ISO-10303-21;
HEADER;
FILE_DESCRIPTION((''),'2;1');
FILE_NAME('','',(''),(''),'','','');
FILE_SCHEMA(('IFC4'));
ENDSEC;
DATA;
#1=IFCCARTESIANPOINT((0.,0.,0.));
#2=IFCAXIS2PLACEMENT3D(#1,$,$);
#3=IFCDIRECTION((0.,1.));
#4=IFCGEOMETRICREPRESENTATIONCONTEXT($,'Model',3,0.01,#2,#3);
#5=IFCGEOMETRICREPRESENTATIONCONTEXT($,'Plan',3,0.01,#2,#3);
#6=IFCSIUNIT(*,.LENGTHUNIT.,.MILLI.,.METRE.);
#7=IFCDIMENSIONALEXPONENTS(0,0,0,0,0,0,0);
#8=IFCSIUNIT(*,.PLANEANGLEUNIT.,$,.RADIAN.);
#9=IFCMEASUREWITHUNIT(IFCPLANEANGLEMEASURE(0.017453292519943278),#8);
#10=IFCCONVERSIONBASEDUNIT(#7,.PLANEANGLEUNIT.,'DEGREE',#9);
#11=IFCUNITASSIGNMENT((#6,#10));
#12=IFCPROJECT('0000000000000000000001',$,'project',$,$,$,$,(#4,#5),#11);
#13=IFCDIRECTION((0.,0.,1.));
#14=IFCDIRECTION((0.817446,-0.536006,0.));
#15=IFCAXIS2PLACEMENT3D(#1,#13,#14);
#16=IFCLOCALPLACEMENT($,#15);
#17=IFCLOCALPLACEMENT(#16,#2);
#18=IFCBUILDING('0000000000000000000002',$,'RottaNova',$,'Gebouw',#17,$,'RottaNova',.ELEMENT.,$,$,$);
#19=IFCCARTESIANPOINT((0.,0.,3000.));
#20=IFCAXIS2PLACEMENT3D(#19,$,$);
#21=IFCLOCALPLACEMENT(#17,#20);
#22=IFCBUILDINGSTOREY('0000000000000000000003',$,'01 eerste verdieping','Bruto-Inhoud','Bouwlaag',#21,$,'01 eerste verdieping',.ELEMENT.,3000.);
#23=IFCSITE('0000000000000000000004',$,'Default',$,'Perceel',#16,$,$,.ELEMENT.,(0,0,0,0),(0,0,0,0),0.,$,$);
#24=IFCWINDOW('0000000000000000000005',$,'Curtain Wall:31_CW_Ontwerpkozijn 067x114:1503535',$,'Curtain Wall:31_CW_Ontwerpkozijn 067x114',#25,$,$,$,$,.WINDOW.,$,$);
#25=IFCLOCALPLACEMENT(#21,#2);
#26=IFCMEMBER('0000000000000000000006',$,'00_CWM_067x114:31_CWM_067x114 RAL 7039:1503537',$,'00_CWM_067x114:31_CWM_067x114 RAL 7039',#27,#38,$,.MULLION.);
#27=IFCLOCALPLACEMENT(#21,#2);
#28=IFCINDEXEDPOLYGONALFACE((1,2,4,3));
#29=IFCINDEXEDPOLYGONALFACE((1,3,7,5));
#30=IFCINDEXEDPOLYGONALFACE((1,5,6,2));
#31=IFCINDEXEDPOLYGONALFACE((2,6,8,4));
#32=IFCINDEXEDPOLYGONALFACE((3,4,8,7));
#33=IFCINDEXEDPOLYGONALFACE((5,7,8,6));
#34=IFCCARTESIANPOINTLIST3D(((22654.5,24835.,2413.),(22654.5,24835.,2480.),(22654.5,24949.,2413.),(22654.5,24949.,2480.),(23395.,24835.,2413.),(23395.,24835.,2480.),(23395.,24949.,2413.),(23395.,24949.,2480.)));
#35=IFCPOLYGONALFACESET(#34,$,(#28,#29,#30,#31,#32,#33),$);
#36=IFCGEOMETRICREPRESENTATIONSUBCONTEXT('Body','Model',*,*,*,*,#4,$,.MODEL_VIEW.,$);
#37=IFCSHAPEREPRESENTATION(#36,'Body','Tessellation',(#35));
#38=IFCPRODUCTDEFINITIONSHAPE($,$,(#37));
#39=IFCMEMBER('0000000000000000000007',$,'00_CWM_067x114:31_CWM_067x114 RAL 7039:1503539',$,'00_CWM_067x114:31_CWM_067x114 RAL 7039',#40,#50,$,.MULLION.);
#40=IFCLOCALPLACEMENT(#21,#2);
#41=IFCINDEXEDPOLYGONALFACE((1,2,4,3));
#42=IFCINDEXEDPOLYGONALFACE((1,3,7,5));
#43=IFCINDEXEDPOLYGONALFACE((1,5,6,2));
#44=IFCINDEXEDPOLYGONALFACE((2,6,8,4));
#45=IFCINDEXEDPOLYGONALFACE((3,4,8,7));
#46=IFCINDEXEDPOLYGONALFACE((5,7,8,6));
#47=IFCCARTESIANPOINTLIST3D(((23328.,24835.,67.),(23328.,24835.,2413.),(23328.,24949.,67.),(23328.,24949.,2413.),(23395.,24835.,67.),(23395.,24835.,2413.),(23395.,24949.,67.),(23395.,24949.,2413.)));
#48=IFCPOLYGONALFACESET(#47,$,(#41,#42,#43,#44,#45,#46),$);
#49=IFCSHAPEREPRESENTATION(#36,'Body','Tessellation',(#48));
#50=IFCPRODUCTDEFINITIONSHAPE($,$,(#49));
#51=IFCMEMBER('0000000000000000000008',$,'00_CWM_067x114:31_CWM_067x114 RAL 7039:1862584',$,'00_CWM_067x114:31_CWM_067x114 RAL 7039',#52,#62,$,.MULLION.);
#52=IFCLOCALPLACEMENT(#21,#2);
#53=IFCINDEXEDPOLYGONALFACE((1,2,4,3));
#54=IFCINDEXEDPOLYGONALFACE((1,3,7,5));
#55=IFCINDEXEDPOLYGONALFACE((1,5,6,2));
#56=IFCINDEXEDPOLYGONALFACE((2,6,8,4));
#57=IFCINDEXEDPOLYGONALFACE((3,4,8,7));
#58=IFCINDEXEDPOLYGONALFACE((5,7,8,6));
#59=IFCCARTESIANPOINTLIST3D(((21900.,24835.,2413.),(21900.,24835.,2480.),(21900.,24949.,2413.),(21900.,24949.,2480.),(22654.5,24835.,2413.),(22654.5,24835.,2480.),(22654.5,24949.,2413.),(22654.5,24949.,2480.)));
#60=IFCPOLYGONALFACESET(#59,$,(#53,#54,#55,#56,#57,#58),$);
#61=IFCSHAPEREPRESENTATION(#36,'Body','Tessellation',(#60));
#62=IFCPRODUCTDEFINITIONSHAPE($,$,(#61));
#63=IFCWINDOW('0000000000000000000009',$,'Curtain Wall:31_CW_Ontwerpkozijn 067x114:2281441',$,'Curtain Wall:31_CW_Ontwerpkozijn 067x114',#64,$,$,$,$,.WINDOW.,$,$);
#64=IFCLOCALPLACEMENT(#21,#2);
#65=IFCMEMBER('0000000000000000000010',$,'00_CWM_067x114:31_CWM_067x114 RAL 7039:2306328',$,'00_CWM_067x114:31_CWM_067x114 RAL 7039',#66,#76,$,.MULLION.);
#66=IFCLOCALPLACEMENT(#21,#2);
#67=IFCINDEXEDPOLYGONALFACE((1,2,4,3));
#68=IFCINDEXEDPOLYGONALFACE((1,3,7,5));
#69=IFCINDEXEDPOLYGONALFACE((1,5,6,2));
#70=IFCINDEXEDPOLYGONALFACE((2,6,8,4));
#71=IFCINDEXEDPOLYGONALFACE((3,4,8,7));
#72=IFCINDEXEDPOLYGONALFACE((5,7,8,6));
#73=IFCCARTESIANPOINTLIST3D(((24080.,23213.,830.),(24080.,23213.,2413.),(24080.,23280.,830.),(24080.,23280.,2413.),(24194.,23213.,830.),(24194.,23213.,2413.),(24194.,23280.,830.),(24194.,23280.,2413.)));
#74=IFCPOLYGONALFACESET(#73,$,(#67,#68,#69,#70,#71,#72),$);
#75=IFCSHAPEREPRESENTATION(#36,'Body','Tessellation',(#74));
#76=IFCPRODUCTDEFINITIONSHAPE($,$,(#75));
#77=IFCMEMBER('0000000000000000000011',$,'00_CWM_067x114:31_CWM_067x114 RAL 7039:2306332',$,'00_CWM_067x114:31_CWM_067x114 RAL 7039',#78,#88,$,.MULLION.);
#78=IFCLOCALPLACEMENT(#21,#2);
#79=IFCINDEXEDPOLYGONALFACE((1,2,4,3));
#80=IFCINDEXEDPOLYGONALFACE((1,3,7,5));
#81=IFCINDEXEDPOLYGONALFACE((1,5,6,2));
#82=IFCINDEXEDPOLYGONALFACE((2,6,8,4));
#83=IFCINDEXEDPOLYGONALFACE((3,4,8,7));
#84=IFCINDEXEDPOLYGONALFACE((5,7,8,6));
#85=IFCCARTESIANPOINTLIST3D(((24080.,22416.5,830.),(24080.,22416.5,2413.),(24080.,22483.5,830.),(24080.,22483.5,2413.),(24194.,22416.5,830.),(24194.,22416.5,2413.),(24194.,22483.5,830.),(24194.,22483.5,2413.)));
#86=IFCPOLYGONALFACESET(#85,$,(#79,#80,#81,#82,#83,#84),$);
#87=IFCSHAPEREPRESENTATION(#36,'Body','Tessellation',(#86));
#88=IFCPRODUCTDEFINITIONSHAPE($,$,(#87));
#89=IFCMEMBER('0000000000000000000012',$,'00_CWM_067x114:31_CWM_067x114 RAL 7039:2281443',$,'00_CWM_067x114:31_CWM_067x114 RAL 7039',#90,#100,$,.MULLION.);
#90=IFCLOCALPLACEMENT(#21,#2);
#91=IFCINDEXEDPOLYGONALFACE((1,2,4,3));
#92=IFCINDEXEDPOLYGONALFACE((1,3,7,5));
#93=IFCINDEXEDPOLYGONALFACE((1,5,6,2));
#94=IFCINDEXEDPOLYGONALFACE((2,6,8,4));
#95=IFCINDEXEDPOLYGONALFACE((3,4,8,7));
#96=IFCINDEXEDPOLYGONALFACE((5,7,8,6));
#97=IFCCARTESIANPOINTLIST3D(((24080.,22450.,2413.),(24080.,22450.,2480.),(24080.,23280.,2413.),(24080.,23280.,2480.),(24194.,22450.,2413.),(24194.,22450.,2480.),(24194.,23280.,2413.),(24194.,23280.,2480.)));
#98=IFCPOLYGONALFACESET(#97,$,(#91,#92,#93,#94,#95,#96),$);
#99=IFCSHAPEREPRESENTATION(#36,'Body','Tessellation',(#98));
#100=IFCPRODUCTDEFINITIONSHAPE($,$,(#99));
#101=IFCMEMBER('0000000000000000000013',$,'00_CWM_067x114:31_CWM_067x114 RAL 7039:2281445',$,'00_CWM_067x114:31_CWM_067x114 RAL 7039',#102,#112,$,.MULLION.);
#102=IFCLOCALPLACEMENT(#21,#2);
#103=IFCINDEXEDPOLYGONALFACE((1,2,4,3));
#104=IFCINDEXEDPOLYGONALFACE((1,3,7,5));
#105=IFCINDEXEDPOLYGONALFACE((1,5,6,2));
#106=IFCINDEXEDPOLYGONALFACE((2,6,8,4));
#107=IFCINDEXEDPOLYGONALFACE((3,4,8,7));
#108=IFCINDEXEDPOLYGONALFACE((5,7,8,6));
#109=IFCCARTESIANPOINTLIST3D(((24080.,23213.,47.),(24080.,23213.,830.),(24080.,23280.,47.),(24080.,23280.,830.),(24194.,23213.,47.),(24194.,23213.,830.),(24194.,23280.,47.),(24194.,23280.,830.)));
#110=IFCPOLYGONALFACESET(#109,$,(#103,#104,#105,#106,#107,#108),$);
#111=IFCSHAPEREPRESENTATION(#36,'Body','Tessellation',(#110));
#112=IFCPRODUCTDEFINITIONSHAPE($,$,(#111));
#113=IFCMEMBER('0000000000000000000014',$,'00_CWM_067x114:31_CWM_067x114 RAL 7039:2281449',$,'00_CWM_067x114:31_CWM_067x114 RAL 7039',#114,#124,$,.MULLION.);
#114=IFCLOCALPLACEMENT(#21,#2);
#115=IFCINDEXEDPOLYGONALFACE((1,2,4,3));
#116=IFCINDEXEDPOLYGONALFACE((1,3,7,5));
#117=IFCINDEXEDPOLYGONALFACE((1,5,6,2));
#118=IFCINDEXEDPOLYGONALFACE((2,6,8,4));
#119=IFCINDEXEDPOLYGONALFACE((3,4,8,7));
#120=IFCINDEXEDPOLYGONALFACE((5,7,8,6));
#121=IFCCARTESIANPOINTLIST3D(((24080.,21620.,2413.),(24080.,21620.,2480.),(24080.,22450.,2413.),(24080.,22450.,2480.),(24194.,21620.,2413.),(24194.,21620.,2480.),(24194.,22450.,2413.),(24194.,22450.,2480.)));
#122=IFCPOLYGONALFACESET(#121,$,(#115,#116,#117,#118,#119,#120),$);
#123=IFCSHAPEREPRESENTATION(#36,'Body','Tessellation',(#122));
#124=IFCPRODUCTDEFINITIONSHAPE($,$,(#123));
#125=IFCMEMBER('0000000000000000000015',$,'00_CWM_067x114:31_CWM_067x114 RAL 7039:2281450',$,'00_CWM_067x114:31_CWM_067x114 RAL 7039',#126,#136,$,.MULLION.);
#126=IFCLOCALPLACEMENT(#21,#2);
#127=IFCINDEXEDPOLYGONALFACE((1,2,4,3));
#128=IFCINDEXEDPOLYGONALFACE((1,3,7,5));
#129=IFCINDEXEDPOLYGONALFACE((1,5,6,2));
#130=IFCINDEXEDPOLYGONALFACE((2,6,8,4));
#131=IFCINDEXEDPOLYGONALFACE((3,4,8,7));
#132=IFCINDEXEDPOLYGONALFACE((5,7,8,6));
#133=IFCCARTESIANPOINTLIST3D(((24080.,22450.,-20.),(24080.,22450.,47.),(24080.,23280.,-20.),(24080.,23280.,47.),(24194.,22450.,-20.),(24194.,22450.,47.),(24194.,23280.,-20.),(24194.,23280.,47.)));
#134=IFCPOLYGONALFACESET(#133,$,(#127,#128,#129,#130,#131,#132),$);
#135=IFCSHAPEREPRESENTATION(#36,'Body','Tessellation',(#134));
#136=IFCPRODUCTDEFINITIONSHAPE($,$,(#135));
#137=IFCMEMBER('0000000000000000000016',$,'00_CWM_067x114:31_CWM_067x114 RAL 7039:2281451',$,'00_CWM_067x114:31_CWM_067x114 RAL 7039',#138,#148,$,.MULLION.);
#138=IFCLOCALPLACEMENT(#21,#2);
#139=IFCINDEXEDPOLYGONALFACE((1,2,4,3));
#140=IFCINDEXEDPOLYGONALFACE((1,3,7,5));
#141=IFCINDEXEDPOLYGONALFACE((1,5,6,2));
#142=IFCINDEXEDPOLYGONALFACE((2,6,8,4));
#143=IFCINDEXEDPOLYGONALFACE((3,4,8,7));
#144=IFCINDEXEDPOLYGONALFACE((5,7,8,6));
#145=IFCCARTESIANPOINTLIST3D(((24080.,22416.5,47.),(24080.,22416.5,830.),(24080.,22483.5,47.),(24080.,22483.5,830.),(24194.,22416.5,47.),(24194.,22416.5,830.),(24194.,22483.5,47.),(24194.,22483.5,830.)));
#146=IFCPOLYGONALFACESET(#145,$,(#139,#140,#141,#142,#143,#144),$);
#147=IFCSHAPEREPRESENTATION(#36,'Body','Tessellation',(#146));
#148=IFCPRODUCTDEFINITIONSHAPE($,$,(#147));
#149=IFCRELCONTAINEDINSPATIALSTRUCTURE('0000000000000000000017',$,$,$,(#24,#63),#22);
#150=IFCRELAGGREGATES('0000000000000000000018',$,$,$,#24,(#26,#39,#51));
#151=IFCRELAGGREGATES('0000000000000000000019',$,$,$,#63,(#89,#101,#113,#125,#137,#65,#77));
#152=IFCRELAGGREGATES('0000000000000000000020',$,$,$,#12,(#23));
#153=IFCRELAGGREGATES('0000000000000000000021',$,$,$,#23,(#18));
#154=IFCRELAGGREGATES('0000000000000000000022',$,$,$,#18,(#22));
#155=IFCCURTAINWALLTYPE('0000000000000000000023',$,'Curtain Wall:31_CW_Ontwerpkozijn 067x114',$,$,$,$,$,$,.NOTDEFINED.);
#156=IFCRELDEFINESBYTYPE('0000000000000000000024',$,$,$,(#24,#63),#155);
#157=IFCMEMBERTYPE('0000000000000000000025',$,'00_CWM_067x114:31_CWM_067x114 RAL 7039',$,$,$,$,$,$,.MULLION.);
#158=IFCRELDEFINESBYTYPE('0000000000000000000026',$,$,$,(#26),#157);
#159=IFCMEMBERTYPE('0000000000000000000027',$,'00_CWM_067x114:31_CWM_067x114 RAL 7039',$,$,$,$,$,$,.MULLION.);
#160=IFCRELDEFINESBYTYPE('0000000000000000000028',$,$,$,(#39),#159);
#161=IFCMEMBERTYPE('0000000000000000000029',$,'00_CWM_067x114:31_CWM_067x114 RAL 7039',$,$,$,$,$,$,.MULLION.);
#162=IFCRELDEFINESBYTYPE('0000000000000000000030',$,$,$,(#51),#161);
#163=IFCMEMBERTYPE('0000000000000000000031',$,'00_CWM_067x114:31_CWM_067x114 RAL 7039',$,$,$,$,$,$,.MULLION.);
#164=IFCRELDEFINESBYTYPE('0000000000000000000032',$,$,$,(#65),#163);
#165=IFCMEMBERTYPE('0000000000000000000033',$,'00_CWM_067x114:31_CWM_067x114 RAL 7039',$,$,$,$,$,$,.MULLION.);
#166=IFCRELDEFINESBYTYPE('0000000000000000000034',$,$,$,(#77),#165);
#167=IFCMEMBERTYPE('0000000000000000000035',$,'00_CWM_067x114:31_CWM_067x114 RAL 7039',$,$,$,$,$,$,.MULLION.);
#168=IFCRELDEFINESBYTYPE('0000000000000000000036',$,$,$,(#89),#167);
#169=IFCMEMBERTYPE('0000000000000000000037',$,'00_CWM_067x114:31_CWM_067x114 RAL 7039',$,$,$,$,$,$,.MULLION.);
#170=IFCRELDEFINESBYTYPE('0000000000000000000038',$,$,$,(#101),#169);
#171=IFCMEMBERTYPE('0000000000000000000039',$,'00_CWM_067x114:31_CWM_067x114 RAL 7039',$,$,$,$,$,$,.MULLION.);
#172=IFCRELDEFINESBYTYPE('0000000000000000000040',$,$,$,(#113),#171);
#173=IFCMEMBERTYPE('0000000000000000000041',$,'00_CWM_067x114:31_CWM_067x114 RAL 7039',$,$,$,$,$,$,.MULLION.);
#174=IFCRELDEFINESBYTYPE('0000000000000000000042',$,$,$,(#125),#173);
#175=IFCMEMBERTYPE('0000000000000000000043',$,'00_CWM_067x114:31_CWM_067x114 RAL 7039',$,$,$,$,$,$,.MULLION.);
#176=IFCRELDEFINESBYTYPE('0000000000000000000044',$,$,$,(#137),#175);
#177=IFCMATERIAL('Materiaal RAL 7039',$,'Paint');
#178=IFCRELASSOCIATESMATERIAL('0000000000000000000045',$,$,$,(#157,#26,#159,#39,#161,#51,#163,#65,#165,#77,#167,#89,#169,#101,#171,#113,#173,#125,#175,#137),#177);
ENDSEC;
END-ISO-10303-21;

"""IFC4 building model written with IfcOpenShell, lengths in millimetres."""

from ifc_helpers import new_model, entity, si_unit, converted_unit, direction, frame, origin, place, context, subcontext, project, spatial, indexed_curve, outline, extrude, source, transform, mapped, material, type_object, type_shapes, element, aggregate, save


model = new_model("IFC4")

# Units and contexts
model_context = context("Model", 3, precision=0.01, world=origin(), true_north=direction((0.0, 1.0)))
plan_context = context("Plan", 3, precision=0.01, world=origin(), true_north=direction((0.0, 1.0)))
body_context = subcontext(model_context, "Body", "Model", "MODEL_VIEW")
ifc_project = project(units=[si_unit("LENGTHUNIT", "METRE", prefix="MILLI"), converted_unit("PLANEANGLEUNIT", "DEGREE", entity("IfcPlaneAngleMeasure", 0.017453292519943278), si_unit("PLANEANGLEUNIT", "RADIAN"), dimensions=[0, 0, 0, 0, 0, 0, 0])], contexts=[model_context, plan_context])

# Site, building, storey
site_placement = place(None, frame((0.0, 0.0, 0.0), z_axis=(0.0, 0.0, 1.0), x_axis=(0.817446, -0.536006, 0.0)))
site = spatial("IfcSite", under=ifc_project, at=site_placement, Name="Default", ObjectType="Perceel", CompositionType="ELEMENT", RefLatitude=(0, 0, 0, 0), RefLongitude=(0, 0, 0, 0), RefElevation=0.0)
building_placement = place(site_placement, origin())
building = spatial("IfcBuilding", under=site, at=building_placement, Name="RottaNova", ObjectType="Gebouw", LongName="RottaNova", CompositionType="ELEMENT")
storey_placement = place(building_placement, frame((0.0, 0.0, 3000.0)))
storey = spatial("IfcBuildingStorey", under=building, at=storey_placement, Name="01 eerste verdieping", Description="Bruto-Inhoud", ObjectType="Bouwlaag", LongName="01 eerste verdieping", CompositionType="ELEMENT", Elevation=3000.0)

# Windows, members
curtain_wall_type = type_object("IfcCurtainWallType", Name="Curtain Wall:31_CW_Ontwerpkozijn 067x114", PredefinedType="NOTDEFINED")
window_1_placement = place(storey_placement, frame((0.0, 0.0, -3000.0)))
window_1 = element("IfcWindow", 1, at=window_1_placement, inside=storey, type_object=curtain_wall_type, Name="Curtain Wall:31_CW_Ontwerpkozijn 067x114:1503535", ObjectType="Curtain Wall:31_CW_Ontwerpkozijn 067x114", PredefinedType="WINDOW")
ifc_material_1 = material(Name="Materiaal RAL 7039", Category="Paint")
member_type_1 = type_object("IfcMemberType", Name="00_CWM_067x114:31_CWM_067x114 RAL 7039", PredefinedType="MULLION", material=ifc_material_1)
shared_shape_1 = source(origin(), body_context, "Body", "SweptSolid", [
    extrude(outline(indexed_curve([(-33.5, -57.0), (33.5, -57.0), (33.5, 57.0), (-33.5, 57.0), (-33.5, -57.0)], self_intersect=False)), frame((-33.5, -57.0, -740.5), z_axis=(0.0, 0.0, 1.0), x_axis=(-1.0, 0.0, 0.0)), (0.0, 0.0, 1.0), 740.5),
])
type_shapes(member_type_1, [shared_shape_1])
member_1_placement = place(window_1_placement, frame((23395.0, 24835.0, 5480.0), z_axis=(1.0, 0.0, 0.0), x_axis=(0.0, 0.0, 1.0)))
member_1 = element("IfcMember", 2, at=member_1_placement, type_object=member_type_1, material=ifc_material_1, Name="00_CWM_067x114:31_CWM_067x114 RAL 7039:1503537", ObjectType="00_CWM_067x114:31_CWM_067x114 RAL 7039", PredefinedType="MULLION", context=body_context, shape_type="MappedRepresentation", body=[
    mapped(shared_shape_1, transform((0.0, 0.0, 0.0), scale=1.0)),
])
member_type_2 = type_object("IfcMemberType", Name="00_CWM_067x114:31_CWM_067x114 RAL 7039", PredefinedType="MULLION", material=ifc_material_1)
shared_shape_2 = source(origin(), body_context, "Body", "SweptSolid", [
    extrude(outline(indexed_curve([(-33.5, -57.0), (33.5, -57.0), (33.5, 57.0), (-33.5, 57.0), (-33.5, -57.0)], self_intersect=False)), frame((-33.5, -57.0, -2346.0), z_axis=(0.0, 0.0, 1.0), x_axis=(-1.0, 0.0, 0.0)), (0.0, 0.0, 1.0), 2346.0),
])
type_shapes(member_type_2, [shared_shape_2])
member_2_placement = place(window_1_placement, frame((23395.0, 24835.0, 3067.0), z_axis=(0.0, 0.0, -1.0), x_axis=(1.0, 0.0, 0.0)))
member_2 = element("IfcMember", 3, at=member_2_placement, type_object=member_type_2, material=ifc_material_1, Name="00_CWM_067x114:31_CWM_067x114 RAL 7039:1503539", ObjectType="00_CWM_067x114:31_CWM_067x114 RAL 7039", PredefinedType="MULLION", context=body_context, shape_type="MappedRepresentation", body=[
    mapped(shared_shape_2, transform((0.0, 0.0, 0.0), scale=1.0)),
])
member_type_3 = type_object("IfcMemberType", Name="00_CWM_067x114:31_CWM_067x114 RAL 7039", PredefinedType="MULLION", material=ifc_material_1)
shared_shape_3 = source(origin(), body_context, "Body", "SweptSolid", [
    extrude(outline(indexed_curve([(-33.5, -57.0), (33.5, -57.0), (33.5, 57.0), (-33.5, 57.0), (-33.5, -57.0)], self_intersect=False)), frame((-33.5, -57.0, -754.5), z_axis=(0.0, 0.0, 1.0), x_axis=(-1.0, 0.0, 0.0)), (0.0, 0.0, 1.0), 754.5),
])
type_shapes(member_type_3, [shared_shape_3])
member_3_placement = place(window_1_placement, frame((22654.5, 24835.0, 5480.0), z_axis=(1.0, 0.0, 0.0), x_axis=(0.0, 0.0, 1.0)))
member_3 = element("IfcMember", 4, at=member_3_placement, type_object=member_type_3, material=ifc_material_1, Name="00_CWM_067x114:31_CWM_067x114 RAL 7039:1862584", ObjectType="00_CWM_067x114:31_CWM_067x114 RAL 7039", PredefinedType="MULLION", context=body_context, shape_type="MappedRepresentation", body=[
    mapped(shared_shape_3, transform((0.0, 0.0, 0.0), scale=1.0)),
])
window_2_placement = place(storey_placement, frame((0.0, 0.0, -3000.0)))
window_2 = element("IfcWindow", 5, at=window_2_placement, inside=storey, type_object=curtain_wall_type, Name="Curtain Wall:31_CW_Ontwerpkozijn 067x114:2281441", ObjectType="Curtain Wall:31_CW_Ontwerpkozijn 067x114", PredefinedType="WINDOW")
member_type_4 = type_object("IfcMemberType", Name="00_CWM_067x114:31_CWM_067x114 RAL 7039", PredefinedType="MULLION", material=ifc_material_1)
shared_shape_4 = source(origin(), body_context, "Body", "SweptSolid", [
    extrude(outline(indexed_curve([(-33.5, -57.0), (33.5, -57.0), (33.5, 57.0), (-33.5, 57.0), (-33.5, -57.0)], self_intersect=False)), frame((-33.5, 57.0, -1583.0), z_axis=(0.0, 0.0, 1.0), x_axis=(-1.0, 0.0, 0.0)), (0.0, 0.0, 1.0), 1583.0),
])
type_shapes(member_type_4, [shared_shape_4])
member_4_placement = place(window_2_placement, frame((24080.0, 23280.0, 3830.0), z_axis=(0.0, 0.0, -1.0), x_axis=(0.0, 1.0, 0.0)))
member_4 = element("IfcMember", 6, at=member_4_placement, type_object=member_type_4, material=ifc_material_1, Name="00_CWM_067x114:31_CWM_067x114 RAL 7039:2306328", ObjectType="00_CWM_067x114:31_CWM_067x114 RAL 7039", PredefinedType="MULLION", context=body_context, shape_type="MappedRepresentation", body=[
    mapped(shared_shape_4, transform((0.0, 0.0, 0.0), scale=1.0)),
])
member_type_5 = type_object("IfcMemberType", Name="00_CWM_067x114:31_CWM_067x114 RAL 7039", PredefinedType="MULLION", material=ifc_material_1)
shared_shape_5 = source(origin(), body_context, "Body", "SweptSolid", [
    extrude(outline(indexed_curve([(-33.5, -57.0), (33.5, -57.0), (33.5, 57.0), (-33.5, 57.0), (-33.5, -57.0)], self_intersect=False)), frame((0.0, 57.0, -1583.0), z_axis=(0.0, 0.0, 1.0), x_axis=(-1.0, 0.0, 0.0)), (0.0, 0.0, 1.0), 1583.0),
])
type_shapes(member_type_5, [shared_shape_5])
member_5_placement = place(window_2_placement, frame((24080.0, 22450.0, 3830.0), z_axis=(0.0, 0.0, -1.0), x_axis=(0.0, 1.0, 0.0)))
member_5 = element("IfcMember", 7, at=member_5_placement, type_object=member_type_5, material=ifc_material_1, Name="00_CWM_067x114:31_CWM_067x114 RAL 7039:2306332", ObjectType="00_CWM_067x114:31_CWM_067x114 RAL 7039", PredefinedType="MULLION", context=body_context, shape_type="MappedRepresentation", body=[
    mapped(shared_shape_5, transform((0.0, 0.0, 0.0), scale=1.0)),
])
member_type_6 = type_object("IfcMemberType", Name="00_CWM_067x114:31_CWM_067x114 RAL 7039", PredefinedType="MULLION", material=ifc_material_1)
shared_shape_6 = source(origin(), body_context, "Body", "SweptSolid", [
    extrude(outline(indexed_curve([(-33.5, -57.0), (33.5, -57.0), (33.5, 57.0), (-33.5, 57.0), (-33.5, -57.0)], self_intersect=False)), frame((-33.5, 57.0, -830.0), z_axis=(0.0, 0.0, 1.0), x_axis=(-1.0, 0.0, 0.0)), (0.0, 0.0, 1.0), 830.0),
])
type_shapes(member_type_6, [shared_shape_6])
member_6_placement = place(window_2_placement, frame((24080.0, 23280.0, 5480.0), z_axis=(0.0, 1.0, 0.0), x_axis=(0.0, 0.0, 1.0)))
member_6 = element("IfcMember", 8, at=member_6_placement, type_object=member_type_6, material=ifc_material_1, Name="00_CWM_067x114:31_CWM_067x114 RAL 7039:2281443", ObjectType="00_CWM_067x114:31_CWM_067x114 RAL 7039", PredefinedType="MULLION", context=body_context, shape_type="MappedRepresentation", body=[
    mapped(shared_shape_6, transform((0.0, 0.0, 0.0), scale=1.0)),
])
member_type_7 = type_object("IfcMemberType", Name="00_CWM_067x114:31_CWM_067x114 RAL 7039", PredefinedType="MULLION", material=ifc_material_1)
shared_shape_7 = source(origin(), body_context, "Body", "SweptSolid", [
    extrude(outline(indexed_curve([(-33.5, -57.0), (33.5, -57.0), (33.5, 57.0), (-33.5, 57.0), (-33.5, -57.0)], self_intersect=False)), frame((-33.5, 57.0, -783.0), z_axis=(0.0, 0.0, 1.0), x_axis=(-1.0, 0.0, 0.0)), (0.0, 0.0, 1.0), 783.0),
])
type_shapes(member_type_7, [shared_shape_7])
member_7_placement = place(window_2_placement, frame((24080.0, 23280.0, 3047.0), z_axis=(0.0, 0.0, -1.0), x_axis=(0.0, 1.0, 0.0)))
member_7 = element("IfcMember", 9, at=member_7_placement, type_object=member_type_7, material=ifc_material_1, Name="00_CWM_067x114:31_CWM_067x114 RAL 7039:2281445", ObjectType="00_CWM_067x114:31_CWM_067x114 RAL 7039", PredefinedType="MULLION", context=body_context, shape_type="MappedRepresentation", body=[
    mapped(shared_shape_7, transform((0.0, 0.0, 0.0), scale=1.0)),
])
member_type_8 = type_object("IfcMemberType", Name="00_CWM_067x114:31_CWM_067x114 RAL 7039", PredefinedType="MULLION", material=ifc_material_1)
shared_shape_8 = source(origin(), body_context, "Body", "SweptSolid", [
    extrude(outline(indexed_curve([(-33.5, -57.0), (33.5, -57.0), (33.5, 57.0), (-33.5, 57.0), (-33.5, -57.0)], self_intersect=False)), frame((-33.5, 57.0, -830.0), z_axis=(0.0, 0.0, 1.0), x_axis=(-1.0, 0.0, 0.0)), (0.0, 0.0, 1.0), 830.0),
])
type_shapes(member_type_8, [shared_shape_8])
member_8_placement = place(window_2_placement, frame((24080.0, 22450.0, 5480.0), z_axis=(0.0, 1.0, 0.0), x_axis=(0.0, 0.0, 1.0)))
member_8 = element("IfcMember", 10, at=member_8_placement, type_object=member_type_8, material=ifc_material_1, Name="00_CWM_067x114:31_CWM_067x114 RAL 7039:2281449", ObjectType="00_CWM_067x114:31_CWM_067x114 RAL 7039", PredefinedType="MULLION", context=body_context, shape_type="MappedRepresentation", body=[
    mapped(shared_shape_8, transform((0.0, 0.0, 0.0), scale=1.0)),
])
member_type_9 = type_object("IfcMemberType", Name="00_CWM_067x114:31_CWM_067x114 RAL 7039", PredefinedType="MULLION", material=ifc_material_1)
shared_shape_9 = source(origin(), body_context, "Body", "SweptSolid", [
    extrude(outline(indexed_curve([(-33.5, -57.0), (33.5, -57.0), (33.5, 57.0), (-33.5, 57.0), (-33.5, -57.0)], self_intersect=False)), frame((-33.5, 57.0, -830.0), z_axis=(0.0, 0.0, 1.0), x_axis=(-1.0, 0.0, 0.0)), (0.0, 0.0, 1.0), 830.0),
])
type_shapes(member_type_9, [shared_shape_9])
member_9_placement = place(window_2_placement, frame((24080.0, 22450.0, 2980.0), z_axis=(0.0, -1.0, 0.0), x_axis=(0.0, 0.0, -1.0)))
member_9 = element("IfcMember", 11, at=member_9_placement, type_object=member_type_9, material=ifc_material_1, Name="00_CWM_067x114:31_CWM_067x114 RAL 7039:2281450", ObjectType="00_CWM_067x114:31_CWM_067x114 RAL 7039", PredefinedType="MULLION", context=body_context, shape_type="MappedRepresentation", body=[
    mapped(shared_shape_9, transform((0.0, 0.0, 0.0), scale=1.0)),
])
member_type_10 = type_object("IfcMemberType", Name="00_CWM_067x114:31_CWM_067x114 RAL 7039", PredefinedType="MULLION", material=ifc_material_1)
shared_shape_10 = source(origin(), body_context, "Body", "SweptSolid", [
    extrude(outline(indexed_curve([(-33.5, -57.0), (33.5, -57.0), (33.5, 57.0), (-33.5, 57.0), (-33.5, -57.0)], self_intersect=False)), frame((0.0, 57.0, -783.0), z_axis=(0.0, 0.0, 1.0), x_axis=(-1.0, 0.0, 0.0)), (0.0, 0.0, 1.0), 783.0),
])
type_shapes(member_type_10, [shared_shape_10])
member_10_placement = place(window_2_placement, frame((24080.0, 22450.0, 3047.0), z_axis=(0.0, 0.0, -1.0), x_axis=(0.0, 1.0, 0.0)))
member_10 = element("IfcMember", 12, at=member_10_placement, type_object=member_type_10, material=ifc_material_1, Name="00_CWM_067x114:31_CWM_067x114 RAL 7039:2281451", ObjectType="00_CWM_067x114:31_CWM_067x114 RAL 7039", PredefinedType="MULLION", context=body_context, shape_type="MappedRepresentation", body=[
    mapped(shared_shape_10, transform((0.0, 0.0, 0.0), scale=1.0)),
])

aggregate(window_1, [member_1, member_2, member_3])
aggregate(window_2, [member_6, member_7, member_8, member_9, member_10, member_4, member_5])

save(model, "model.ifc")
